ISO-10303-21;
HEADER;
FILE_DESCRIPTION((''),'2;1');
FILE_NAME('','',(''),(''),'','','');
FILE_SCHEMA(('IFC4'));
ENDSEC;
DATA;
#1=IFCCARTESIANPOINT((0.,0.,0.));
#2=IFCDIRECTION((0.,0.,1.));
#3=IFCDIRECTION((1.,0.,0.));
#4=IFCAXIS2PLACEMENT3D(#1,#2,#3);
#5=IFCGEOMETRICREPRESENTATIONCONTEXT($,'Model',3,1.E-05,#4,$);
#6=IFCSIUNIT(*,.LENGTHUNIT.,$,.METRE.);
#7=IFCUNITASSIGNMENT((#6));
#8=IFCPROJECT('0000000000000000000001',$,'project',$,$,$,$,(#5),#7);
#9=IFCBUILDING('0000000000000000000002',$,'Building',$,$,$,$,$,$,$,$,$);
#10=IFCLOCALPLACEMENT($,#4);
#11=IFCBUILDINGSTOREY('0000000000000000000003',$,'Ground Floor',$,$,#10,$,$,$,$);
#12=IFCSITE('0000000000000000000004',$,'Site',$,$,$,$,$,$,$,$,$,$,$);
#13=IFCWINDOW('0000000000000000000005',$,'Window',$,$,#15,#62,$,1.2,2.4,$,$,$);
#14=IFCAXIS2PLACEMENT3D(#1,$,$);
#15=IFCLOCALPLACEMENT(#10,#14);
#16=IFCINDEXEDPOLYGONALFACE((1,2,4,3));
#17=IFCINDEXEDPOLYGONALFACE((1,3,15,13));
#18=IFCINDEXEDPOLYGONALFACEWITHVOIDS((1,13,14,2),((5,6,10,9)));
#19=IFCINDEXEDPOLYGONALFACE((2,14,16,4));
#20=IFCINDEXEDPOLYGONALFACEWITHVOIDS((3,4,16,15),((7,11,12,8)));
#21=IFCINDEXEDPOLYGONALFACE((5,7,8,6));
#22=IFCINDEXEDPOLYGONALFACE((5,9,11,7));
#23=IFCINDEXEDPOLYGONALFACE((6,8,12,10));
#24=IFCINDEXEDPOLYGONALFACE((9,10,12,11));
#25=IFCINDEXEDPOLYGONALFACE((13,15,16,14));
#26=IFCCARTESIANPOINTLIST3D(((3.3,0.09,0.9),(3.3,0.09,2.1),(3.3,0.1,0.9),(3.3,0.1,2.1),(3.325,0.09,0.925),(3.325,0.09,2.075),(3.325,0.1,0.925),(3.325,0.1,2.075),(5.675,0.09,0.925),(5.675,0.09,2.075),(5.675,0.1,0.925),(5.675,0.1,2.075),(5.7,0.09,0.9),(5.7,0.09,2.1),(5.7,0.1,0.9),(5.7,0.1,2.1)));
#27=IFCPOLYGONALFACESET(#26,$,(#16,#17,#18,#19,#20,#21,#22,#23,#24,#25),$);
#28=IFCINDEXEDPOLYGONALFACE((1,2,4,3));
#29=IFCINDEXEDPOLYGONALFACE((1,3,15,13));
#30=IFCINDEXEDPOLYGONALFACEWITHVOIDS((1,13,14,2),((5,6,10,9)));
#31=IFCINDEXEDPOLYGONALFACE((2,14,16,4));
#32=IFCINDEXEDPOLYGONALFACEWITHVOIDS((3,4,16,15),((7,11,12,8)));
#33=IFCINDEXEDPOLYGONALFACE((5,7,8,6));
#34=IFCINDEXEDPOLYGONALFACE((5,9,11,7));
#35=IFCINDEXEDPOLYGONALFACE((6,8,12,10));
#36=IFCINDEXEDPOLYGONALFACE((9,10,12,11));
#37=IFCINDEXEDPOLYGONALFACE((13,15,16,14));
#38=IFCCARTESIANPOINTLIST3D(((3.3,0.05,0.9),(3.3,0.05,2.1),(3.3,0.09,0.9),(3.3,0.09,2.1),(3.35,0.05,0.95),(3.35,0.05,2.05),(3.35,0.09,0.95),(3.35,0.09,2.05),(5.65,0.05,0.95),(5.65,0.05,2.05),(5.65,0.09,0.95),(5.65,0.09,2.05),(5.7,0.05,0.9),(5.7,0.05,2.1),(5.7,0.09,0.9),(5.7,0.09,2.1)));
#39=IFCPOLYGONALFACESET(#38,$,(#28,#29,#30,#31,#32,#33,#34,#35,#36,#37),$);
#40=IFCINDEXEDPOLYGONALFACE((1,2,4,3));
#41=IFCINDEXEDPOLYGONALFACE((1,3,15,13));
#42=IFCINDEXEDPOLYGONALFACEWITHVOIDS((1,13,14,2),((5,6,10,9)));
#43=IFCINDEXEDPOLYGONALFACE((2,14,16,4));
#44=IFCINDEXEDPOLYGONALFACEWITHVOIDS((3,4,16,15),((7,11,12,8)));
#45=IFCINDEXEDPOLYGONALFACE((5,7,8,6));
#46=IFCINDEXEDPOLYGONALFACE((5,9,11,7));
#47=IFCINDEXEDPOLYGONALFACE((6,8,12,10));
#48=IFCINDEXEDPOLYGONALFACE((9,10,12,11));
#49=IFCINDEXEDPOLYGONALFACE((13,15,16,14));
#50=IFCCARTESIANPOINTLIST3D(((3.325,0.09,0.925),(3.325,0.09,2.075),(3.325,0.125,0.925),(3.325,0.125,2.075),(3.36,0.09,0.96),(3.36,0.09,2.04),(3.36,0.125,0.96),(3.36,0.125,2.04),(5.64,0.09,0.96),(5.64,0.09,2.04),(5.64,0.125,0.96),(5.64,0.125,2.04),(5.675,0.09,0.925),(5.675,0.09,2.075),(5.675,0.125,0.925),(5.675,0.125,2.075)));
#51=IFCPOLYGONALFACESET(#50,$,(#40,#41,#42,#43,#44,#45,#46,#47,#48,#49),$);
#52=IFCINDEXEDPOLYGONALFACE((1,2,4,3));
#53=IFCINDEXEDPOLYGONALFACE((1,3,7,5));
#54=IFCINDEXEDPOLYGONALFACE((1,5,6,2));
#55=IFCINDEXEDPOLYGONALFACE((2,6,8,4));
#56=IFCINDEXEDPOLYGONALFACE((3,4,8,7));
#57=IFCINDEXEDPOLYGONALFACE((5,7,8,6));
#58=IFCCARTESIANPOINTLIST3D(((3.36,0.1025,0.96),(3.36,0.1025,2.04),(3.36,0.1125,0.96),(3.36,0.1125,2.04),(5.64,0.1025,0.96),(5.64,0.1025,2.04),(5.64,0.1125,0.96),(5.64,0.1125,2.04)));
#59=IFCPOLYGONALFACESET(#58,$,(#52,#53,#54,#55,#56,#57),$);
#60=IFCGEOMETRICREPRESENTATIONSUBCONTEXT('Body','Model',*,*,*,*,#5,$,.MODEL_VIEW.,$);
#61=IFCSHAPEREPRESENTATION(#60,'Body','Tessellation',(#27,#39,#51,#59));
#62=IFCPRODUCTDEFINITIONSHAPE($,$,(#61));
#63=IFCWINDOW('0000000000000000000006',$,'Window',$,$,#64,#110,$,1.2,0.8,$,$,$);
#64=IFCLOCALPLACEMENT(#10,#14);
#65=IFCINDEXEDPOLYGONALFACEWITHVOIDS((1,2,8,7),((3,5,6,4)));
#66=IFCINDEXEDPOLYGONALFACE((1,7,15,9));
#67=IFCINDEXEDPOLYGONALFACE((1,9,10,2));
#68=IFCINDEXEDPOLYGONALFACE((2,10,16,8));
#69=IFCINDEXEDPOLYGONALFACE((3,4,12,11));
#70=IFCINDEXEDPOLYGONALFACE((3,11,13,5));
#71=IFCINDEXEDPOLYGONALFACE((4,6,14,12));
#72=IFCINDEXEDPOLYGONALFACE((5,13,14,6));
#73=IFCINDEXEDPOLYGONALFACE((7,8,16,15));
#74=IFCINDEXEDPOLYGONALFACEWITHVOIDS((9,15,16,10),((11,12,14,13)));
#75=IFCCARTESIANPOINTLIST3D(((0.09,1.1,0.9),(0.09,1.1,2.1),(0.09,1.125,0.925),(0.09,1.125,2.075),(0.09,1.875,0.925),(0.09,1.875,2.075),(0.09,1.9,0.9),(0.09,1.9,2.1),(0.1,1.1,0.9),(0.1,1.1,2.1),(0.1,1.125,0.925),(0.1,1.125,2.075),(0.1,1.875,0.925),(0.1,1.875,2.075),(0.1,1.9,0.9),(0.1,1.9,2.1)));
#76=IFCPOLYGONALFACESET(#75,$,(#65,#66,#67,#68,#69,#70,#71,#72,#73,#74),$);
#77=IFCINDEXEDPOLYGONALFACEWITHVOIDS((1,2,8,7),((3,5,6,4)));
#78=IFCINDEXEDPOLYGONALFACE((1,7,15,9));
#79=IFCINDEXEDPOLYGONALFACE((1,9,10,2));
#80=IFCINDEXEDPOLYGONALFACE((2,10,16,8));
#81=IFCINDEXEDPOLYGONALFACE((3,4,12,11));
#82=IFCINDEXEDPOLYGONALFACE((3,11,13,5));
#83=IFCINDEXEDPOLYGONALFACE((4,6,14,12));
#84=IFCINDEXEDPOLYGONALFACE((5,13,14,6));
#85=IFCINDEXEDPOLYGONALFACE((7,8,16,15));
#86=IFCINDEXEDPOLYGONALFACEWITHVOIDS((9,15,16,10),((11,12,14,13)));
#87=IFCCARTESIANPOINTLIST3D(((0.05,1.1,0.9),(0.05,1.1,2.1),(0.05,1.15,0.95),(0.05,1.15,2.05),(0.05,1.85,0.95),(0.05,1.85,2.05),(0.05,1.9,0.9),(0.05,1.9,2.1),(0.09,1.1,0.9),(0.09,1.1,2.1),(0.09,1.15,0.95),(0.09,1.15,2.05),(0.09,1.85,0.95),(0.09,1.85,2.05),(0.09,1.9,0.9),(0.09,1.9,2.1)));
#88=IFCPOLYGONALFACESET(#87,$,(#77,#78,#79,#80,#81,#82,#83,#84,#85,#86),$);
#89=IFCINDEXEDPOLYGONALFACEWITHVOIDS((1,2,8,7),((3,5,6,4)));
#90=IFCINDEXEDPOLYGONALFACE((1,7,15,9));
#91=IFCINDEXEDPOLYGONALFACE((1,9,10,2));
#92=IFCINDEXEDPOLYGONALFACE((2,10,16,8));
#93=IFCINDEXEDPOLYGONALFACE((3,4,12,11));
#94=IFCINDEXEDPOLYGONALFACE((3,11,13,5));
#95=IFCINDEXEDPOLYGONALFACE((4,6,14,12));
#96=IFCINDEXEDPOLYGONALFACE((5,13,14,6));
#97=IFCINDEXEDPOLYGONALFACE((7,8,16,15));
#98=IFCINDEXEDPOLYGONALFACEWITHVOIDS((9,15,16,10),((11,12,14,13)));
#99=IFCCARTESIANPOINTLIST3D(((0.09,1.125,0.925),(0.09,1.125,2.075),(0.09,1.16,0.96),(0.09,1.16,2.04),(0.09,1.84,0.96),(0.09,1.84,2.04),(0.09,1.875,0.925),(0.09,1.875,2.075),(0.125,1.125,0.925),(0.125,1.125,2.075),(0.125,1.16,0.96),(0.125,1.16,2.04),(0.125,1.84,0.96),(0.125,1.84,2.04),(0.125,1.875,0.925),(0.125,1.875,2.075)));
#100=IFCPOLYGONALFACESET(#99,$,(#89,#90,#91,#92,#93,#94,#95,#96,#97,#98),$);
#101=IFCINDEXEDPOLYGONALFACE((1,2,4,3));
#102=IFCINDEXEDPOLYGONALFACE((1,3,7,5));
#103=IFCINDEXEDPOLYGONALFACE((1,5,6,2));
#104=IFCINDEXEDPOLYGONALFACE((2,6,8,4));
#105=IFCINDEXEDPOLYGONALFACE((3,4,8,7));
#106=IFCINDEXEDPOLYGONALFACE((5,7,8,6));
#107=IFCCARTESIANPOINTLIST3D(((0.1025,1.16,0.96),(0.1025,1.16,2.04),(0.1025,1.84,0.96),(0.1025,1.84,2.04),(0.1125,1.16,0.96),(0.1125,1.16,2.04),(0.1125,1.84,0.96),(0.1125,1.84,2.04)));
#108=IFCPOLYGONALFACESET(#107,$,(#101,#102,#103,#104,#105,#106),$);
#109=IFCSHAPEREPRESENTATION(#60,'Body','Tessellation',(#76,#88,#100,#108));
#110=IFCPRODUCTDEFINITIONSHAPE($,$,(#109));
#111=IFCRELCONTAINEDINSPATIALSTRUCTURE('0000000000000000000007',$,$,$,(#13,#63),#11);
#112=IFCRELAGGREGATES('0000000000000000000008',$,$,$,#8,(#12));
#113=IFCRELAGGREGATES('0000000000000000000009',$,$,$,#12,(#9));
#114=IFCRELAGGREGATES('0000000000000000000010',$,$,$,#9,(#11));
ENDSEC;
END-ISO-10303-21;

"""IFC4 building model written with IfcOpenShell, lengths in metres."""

from ifc_helpers import new_model, si_unit, frame, origin_with_axes, place, context, subcontext, project, spatial, line, indexed_curve, outline, extrude, element, save


model = new_model("IFC4")

# Units and contexts
model_context = context("Model", 3, precision=1e-05, world=origin_with_axes())
body_context = subcontext(model_context, "Body", "Model", "MODEL_VIEW")
ifc_project = project(units=[si_unit("LENGTHUNIT", "METRE")], contexts=[model_context])

# Site, building, storey
site = spatial("IfcSite", under=ifc_project, Name="Site")
building = spatial("IfcBuilding", under=site, Name="Building")
storey_placement = place(None, origin_with_axes())
storey = spatial("IfcBuildingStorey", under=building, at=storey_placement, Name="Ground Floor")

# Windows
window_1_placement = place(storey_placement, frame((3.3, 0.0, 0.9), z_axis=(0.0, 0.0, 1.0), x_axis=(1.0, 0.0, 0.0)))
element("IfcWindow", 1, at=window_1_placement, inside=storey, Name="Window", OverallHeight=1.2, OverallWidth=2.4, context=body_context, shape_type="SweptSolid", body=[
    extrude(outline(indexed_curve([(0.0, 0.0), (2.4, 0.0), (2.4, 1.2), (0.0, 1.2)], segments=[line(1, 2, 3, 4, 1)]), holes=[indexed_curve([(0.025, 0.025), (2.375, 0.025), (2.375, 1.175), (0.025, 1.175)], segments=[line(1, 2, 3, 4, 1)])]), frame((0.0, 0.09, 0.0), z_axis=(0.0, -1.0, 0.0), x_axis=(1.0, 0.0, 0.0)), (0.0, 0.0, -1.0), 0.01),
    extrude(outline(indexed_curve([(0.0, 0.0), (2.4, 0.0), (2.4, 1.2), (0.0, 1.2)], segments=[line(1, 2, 3, 4, 1)]), holes=[indexed_curve([(0.05, 0.05), (2.35, 0.05), (2.35, 1.15), (0.05, 1.15)], segments=[line(1, 2, 3, 4, 1)])]), frame((0.0, 0.05, 0.0), z_axis=(0.0, -1.0, 0.0), x_axis=(1.0, 0.0, 0.0)), (0.0, 0.0, -1.0), 0.04),
    extrude(outline(indexed_curve([(0.0, 0.0), (2.35, 0.0), (2.35, 1.15), (0.0, 1.15)], segments=[line(1, 2, 3, 4, 1)]), holes=[indexed_curve([(0.035, 0.035), (2.315, 0.035), (2.315, 1.115), (0.035, 1.115)], segments=[line(1, 2, 3, 4, 1)])]), frame((0.025, 0.09, 0.025), z_axis=(0.0, -1.0, 0.0), x_axis=(1.0, 0.0, 0.0)), (0.0, 0.0, -1.0), 0.035),
    extrude(outline(indexed_curve([(0.035, 0.035), (2.315, 0.035), (2.315, 1.115), (0.035, 1.115)], segments=[line(1, 2, 3, 4, 1)])), frame((0.025, 0.1025, 0.025), z_axis=(0.0, -1.0, 0.0), x_axis=(1.0, 0.0, 0.0)), (0.0, 0.0, -1.0), 0.01),
])
window_2_placement = place(storey_placement, frame((0.0, 1.9, 0.9), z_axis=(0.0, 0.0, 1.0), x_axis=(0.0, -1.0, 0.0)))
element("IfcWindow", 2, at=window_2_placement, inside=storey, Name="Window", OverallHeight=1.2, OverallWidth=0.8, context=body_context, shape_type="SweptSolid", body=[
    extrude(outline(indexed_curve([(0.0, 0.0), (0.8, 0.0), (0.8, 1.2), (0.0, 1.2)], segments=[line(1, 2, 3, 4, 1)]), holes=[indexed_curve([(0.025, 0.025), (0.775, 0.025), (0.775, 1.175), (0.025, 1.175)], segments=[line(1, 2, 3, 4, 1)])]), frame((0.0, 0.09, 0.0), z_axis=(0.0, -1.0, 0.0), x_axis=(1.0, 0.0, 0.0)), (0.0, 0.0, -1.0), 0.01),
    extrude(outline(indexed_curve([(0.0, 0.0), (0.8, 0.0), (0.8, 1.2), (0.0, 1.2)], segments=[line(1, 2, 3, 4, 1)]), holes=[indexed_curve([(0.05, 0.05), (0.75, 0.05), (0.75, 1.15), (0.05, 1.15)], segments=[line(1, 2, 3, 4, 1)])]), frame((0.0, 0.05, 0.0), z_axis=(0.0, -1.0, 0.0), x_axis=(1.0, 0.0, 0.0)), (0.0, 0.0, -1.0), 0.04),
    extrude(outline(indexed_curve([(0.0, 0.0), (0.75, 0.0), (0.75, 1.15), (0.0, 1.15)], segments=[line(1, 2, 3, 4, 1)]), holes=[indexed_curve([(0.035, 0.035), (0.715, 0.035), (0.715, 1.115), (0.035, 1.115)], segments=[line(1, 2, 3, 4, 1)])]), frame((0.025, 0.09, 0.025), z_axis=(0.0, -1.0, 0.0), x_axis=(1.0, 0.0, 0.0)), (0.0, 0.0, -1.0), 0.035),
    extrude(outline(indexed_curve([(0.035, 0.035), (0.715, 0.035), (0.715, 1.115), (0.035, 1.115)], segments=[line(1, 2, 3, 4, 1)])), frame((0.025, 0.1025, 0.025), z_axis=(0.0, -1.0, 0.0), x_axis=(1.0, 0.0, 0.0)), (0.0, 0.0, -1.0), 0.01),
])

save(model, "model.ifc")
